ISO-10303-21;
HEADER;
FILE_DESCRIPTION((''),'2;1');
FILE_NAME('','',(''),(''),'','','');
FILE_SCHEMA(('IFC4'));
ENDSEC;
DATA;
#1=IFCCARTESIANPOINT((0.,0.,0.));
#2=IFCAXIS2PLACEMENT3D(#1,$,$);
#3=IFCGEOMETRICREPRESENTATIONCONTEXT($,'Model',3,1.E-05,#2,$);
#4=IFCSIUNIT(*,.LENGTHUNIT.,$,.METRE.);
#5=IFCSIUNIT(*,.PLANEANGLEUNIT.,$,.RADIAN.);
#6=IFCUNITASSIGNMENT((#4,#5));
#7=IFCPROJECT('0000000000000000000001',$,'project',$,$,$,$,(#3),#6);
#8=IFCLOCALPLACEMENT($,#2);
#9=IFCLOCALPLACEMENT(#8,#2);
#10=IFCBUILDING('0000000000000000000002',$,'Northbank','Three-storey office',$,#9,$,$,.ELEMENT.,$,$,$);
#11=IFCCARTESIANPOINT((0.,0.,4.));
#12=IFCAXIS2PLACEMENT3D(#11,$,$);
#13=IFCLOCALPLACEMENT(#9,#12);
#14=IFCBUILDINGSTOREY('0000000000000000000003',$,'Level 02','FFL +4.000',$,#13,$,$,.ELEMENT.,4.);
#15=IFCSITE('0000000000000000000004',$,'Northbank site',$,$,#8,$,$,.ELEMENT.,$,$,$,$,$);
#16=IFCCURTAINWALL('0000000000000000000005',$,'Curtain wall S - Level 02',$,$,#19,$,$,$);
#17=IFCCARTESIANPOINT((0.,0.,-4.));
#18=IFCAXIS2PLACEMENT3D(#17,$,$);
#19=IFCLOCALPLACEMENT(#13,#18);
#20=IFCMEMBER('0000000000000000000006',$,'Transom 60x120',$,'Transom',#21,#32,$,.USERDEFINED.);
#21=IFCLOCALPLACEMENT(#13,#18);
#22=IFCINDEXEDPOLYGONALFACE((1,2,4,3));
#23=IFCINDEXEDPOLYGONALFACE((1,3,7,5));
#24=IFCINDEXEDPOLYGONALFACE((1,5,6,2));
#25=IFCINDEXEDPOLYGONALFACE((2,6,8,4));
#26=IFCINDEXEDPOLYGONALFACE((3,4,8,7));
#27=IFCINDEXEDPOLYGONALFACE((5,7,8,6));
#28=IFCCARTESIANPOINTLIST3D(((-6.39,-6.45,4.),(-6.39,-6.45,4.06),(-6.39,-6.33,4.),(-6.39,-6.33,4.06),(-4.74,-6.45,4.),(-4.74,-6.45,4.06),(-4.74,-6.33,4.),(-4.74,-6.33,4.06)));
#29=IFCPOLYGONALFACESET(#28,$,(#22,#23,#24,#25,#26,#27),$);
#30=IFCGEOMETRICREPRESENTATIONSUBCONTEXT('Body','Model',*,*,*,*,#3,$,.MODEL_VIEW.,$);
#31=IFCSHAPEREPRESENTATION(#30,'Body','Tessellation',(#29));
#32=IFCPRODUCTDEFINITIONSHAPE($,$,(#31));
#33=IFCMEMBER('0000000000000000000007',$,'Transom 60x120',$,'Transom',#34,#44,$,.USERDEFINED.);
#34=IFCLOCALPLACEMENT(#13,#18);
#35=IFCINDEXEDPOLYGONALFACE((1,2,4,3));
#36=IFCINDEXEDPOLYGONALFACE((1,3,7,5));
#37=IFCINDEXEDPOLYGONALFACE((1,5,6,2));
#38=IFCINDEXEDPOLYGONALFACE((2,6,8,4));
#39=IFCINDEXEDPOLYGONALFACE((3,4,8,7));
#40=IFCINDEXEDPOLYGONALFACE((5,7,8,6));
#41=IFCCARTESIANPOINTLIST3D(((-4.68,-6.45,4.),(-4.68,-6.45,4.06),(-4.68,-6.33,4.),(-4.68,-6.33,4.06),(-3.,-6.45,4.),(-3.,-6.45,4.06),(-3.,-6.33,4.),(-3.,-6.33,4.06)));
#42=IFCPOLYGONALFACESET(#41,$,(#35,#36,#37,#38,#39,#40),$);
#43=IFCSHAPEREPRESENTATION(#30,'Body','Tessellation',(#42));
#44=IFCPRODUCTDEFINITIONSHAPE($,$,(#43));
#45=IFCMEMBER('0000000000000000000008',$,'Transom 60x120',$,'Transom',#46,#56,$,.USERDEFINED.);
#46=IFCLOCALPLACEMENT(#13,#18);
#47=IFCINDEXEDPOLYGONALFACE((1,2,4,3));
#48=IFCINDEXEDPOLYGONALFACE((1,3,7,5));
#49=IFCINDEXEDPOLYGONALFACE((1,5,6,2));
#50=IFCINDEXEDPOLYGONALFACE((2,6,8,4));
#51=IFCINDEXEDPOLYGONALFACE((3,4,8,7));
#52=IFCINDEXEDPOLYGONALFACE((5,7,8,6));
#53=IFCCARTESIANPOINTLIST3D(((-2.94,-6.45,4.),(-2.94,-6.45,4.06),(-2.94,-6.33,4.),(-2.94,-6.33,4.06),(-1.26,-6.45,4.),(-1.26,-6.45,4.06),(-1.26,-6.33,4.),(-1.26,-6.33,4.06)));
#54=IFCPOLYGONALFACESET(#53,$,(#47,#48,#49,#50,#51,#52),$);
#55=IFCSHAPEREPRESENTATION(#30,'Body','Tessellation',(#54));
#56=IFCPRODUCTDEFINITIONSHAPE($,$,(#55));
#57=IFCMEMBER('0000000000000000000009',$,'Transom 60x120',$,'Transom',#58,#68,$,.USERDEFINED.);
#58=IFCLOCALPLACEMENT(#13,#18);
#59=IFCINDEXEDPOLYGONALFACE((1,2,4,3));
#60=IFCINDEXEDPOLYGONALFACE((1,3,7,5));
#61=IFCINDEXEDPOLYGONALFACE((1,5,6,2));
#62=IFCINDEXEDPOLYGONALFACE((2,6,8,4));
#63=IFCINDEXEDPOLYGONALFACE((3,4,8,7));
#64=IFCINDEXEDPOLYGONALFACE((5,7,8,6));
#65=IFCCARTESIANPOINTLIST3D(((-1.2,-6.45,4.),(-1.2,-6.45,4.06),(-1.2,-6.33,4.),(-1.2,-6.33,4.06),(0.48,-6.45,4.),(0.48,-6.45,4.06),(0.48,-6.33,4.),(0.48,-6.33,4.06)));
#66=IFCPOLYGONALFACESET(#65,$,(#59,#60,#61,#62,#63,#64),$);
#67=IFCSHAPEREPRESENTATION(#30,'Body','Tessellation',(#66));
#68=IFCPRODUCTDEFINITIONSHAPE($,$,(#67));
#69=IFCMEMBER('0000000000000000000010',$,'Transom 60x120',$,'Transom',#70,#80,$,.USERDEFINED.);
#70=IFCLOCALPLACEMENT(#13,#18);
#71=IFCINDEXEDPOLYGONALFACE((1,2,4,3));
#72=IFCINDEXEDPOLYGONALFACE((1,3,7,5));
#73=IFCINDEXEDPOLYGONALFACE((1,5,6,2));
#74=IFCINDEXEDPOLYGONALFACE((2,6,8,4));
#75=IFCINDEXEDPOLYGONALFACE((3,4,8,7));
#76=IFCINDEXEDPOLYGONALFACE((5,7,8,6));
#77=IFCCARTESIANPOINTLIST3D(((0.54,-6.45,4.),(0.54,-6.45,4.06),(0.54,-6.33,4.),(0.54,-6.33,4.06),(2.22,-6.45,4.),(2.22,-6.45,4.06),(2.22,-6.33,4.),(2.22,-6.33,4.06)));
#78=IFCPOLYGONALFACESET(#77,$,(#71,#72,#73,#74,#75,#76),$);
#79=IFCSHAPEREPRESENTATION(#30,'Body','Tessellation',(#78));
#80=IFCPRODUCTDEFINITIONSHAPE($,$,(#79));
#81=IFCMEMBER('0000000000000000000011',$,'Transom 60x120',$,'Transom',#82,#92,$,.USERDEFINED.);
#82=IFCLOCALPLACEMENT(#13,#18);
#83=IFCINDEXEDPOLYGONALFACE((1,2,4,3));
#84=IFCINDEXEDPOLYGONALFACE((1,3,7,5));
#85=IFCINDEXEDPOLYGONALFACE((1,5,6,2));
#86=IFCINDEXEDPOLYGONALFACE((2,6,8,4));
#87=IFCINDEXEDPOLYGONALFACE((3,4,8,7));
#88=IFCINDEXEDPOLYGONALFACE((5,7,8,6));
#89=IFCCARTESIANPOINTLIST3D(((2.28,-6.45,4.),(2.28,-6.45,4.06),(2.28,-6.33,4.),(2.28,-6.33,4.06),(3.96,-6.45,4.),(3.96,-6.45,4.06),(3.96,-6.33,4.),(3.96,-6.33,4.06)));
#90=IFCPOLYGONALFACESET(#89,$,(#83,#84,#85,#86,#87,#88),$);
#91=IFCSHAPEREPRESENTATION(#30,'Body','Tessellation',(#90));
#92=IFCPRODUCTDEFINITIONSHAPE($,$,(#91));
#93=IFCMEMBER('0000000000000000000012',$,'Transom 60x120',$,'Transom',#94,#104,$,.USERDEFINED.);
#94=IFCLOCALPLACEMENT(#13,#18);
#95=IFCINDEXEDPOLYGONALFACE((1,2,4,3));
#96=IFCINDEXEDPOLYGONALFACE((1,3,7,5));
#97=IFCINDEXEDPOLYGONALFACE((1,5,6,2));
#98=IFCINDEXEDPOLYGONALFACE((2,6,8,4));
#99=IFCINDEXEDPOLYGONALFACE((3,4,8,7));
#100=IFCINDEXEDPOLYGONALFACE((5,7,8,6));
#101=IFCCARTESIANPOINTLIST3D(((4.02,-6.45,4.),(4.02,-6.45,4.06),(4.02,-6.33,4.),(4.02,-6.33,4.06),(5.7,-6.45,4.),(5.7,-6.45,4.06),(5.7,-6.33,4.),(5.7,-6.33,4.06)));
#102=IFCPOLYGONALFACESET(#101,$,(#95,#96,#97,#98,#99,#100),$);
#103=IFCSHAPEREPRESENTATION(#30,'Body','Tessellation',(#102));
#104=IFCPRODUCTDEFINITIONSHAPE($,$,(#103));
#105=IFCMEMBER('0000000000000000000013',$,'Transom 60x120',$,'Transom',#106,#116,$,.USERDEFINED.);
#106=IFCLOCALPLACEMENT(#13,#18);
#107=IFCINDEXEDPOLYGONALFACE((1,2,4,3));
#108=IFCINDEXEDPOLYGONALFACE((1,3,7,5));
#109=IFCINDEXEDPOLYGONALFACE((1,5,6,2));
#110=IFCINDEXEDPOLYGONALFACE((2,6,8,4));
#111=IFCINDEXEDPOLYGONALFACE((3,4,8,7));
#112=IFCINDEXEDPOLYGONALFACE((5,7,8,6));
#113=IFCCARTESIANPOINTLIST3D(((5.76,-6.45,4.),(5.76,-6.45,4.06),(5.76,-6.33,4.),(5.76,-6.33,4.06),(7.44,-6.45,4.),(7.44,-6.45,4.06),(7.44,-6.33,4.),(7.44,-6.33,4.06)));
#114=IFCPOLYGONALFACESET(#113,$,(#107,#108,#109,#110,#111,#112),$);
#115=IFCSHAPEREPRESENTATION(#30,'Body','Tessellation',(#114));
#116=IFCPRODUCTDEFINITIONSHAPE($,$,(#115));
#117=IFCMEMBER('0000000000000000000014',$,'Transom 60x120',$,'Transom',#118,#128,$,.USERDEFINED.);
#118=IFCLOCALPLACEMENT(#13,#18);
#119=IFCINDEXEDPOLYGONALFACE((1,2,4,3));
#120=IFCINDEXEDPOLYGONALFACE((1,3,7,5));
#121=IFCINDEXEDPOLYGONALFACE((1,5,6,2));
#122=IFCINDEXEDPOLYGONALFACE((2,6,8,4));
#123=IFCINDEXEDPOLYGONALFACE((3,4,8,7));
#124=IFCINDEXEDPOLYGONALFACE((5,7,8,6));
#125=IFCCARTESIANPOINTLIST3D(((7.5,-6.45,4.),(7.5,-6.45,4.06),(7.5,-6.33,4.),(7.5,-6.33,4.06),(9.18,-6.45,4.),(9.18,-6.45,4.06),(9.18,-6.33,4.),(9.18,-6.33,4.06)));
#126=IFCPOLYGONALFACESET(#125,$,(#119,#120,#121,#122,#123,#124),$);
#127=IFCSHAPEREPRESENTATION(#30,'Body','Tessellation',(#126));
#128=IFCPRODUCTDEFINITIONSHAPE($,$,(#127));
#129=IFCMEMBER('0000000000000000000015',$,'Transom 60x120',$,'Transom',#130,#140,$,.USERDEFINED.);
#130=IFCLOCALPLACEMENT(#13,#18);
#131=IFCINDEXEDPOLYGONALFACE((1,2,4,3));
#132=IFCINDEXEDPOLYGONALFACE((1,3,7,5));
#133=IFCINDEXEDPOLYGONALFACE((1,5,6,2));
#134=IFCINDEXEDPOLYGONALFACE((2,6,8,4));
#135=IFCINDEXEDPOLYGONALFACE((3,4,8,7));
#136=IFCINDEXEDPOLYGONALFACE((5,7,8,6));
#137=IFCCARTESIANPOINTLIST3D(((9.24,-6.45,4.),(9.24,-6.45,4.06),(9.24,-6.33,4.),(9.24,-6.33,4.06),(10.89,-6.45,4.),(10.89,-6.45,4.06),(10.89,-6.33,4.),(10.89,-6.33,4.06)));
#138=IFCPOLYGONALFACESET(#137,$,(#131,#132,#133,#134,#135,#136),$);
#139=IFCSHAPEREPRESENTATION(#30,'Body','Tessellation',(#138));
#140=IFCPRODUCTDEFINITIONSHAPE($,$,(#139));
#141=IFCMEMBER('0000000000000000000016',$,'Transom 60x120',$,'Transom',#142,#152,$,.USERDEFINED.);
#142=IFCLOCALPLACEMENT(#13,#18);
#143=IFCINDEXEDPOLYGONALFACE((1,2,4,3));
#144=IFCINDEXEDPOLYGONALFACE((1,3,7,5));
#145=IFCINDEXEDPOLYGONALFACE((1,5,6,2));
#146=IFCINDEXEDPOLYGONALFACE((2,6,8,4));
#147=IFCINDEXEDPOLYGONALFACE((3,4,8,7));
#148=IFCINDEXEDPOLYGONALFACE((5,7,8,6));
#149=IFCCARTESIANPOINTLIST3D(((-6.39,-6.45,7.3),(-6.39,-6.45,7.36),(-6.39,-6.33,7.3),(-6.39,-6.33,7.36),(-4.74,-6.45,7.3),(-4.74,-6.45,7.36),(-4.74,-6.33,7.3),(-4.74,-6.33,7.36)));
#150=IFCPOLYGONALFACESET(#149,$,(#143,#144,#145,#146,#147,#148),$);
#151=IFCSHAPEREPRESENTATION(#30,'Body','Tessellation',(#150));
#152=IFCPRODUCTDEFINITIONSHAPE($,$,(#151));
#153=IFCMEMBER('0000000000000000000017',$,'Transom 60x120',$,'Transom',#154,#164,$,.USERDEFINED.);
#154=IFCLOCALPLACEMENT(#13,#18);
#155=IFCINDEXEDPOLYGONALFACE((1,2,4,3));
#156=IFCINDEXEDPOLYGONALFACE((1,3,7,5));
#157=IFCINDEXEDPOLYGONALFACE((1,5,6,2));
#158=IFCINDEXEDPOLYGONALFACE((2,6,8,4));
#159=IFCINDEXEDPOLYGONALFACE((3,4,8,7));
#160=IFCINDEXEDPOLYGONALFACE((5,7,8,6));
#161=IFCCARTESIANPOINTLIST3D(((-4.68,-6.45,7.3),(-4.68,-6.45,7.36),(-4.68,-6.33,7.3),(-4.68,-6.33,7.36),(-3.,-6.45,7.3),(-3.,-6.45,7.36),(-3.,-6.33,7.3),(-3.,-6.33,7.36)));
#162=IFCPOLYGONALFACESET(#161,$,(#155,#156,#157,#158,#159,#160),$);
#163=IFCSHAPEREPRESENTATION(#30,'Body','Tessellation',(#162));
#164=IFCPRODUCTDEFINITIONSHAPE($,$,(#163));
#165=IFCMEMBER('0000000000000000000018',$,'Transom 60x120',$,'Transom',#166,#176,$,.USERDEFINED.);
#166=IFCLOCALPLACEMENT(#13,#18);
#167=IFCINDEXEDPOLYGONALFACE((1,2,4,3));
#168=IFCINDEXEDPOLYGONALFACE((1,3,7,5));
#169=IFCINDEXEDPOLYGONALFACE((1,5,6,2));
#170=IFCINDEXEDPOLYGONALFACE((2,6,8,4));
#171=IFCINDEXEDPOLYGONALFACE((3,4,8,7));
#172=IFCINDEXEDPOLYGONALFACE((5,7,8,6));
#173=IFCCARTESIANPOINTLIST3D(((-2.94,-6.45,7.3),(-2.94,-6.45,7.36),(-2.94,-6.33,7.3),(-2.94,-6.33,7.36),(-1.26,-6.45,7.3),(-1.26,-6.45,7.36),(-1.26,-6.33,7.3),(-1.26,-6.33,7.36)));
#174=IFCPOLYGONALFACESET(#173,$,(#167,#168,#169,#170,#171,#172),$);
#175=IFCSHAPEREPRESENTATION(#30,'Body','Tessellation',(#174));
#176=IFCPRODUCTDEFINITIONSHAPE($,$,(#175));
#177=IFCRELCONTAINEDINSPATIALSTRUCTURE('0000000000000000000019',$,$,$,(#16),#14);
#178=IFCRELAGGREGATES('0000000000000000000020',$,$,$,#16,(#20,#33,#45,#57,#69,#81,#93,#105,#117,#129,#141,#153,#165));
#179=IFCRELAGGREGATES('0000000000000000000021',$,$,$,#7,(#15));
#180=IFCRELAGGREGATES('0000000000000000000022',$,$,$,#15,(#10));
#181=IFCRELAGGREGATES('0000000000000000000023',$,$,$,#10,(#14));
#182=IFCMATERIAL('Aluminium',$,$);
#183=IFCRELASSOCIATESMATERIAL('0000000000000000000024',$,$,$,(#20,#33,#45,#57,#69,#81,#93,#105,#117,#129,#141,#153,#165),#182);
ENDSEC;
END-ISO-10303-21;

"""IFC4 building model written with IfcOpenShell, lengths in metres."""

from ifc_helpers import new_model, si_unit, frame, origin, place, context, subcontext, project, spatial, rectangle, extrude, material, element, aggregate, save


model = new_model("IFC4")

# Units and contexts
model_context = context("Model", 3, precision=1e-05, world=origin())
body_context = subcontext(model_context, "Body", "Model", "MODEL_VIEW")
ifc_project = project(units=[si_unit("LENGTHUNIT", "METRE"), si_unit("PLANEANGLEUNIT", "RADIAN")], contexts=[model_context])

# Site, building, storey
site_placement = place(None, origin())
site = spatial("IfcSite", under=ifc_project, at=site_placement, Name="Northbank site", CompositionType="ELEMENT")
building_placement = place(site_placement, origin())
building = spatial("IfcBuilding", under=site, at=building_placement, Name="Northbank", Description="Three-storey office", CompositionType="ELEMENT")
storey_placement = place(building_placement, frame((0.0, 0.0, 4.0)))
storey = spatial("IfcBuildingStorey", under=building, at=storey_placement, Name="Level 02", Description="FFL +4.000", CompositionType="ELEMENT", Elevation=4.0)

# Curtain wall, members
curtain_wall_placement = place(storey_placement, frame((0.0, 0.0, -4.0)))
curtain_wall = element("IfcCurtainWall", 1, at=curtain_wall_placement, inside=storey, Name="Curtain wall S - Level 02")
ifc_material = material(Name="Aluminium")
member_1_placement = place(storey_placement, frame((0.0, 0.0, -4.0)))
member_1 = element("IfcMember", 2, at=member_1_placement, material=ifc_material, Name="Transom 60x120", ObjectType="Transom", PredefinedType="USERDEFINED", context=body_context, shape_type="SweptSolid", body=[
    extrude(rectangle(XDim=1.65, YDim=0.12), frame((-5.565, -6.39, 4.0)), (0.0, 0.0, 1.0), 0.06),
])
member_2_placement = place(storey_placement, frame((0.0, 0.0, -4.0)))
member_2 = element("IfcMember", 3, at=member_2_placement, material=ifc_material, Name="Transom 60x120", ObjectType="Transom", PredefinedType="USERDEFINED", context=body_context, shape_type="SweptSolid", body=[
    extrude(rectangle(XDim=1.68, YDim=0.12), frame((-3.84, -6.39, 4.0)), (0.0, 0.0, 1.0), 0.06),
])
member_3_placement = place(storey_placement, frame((0.0, 0.0, -4.0)))
member_3 = element("IfcMember", 4, at=member_3_placement, material=ifc_material, Name="Transom 60x120", ObjectType="Transom", PredefinedType="USERDEFINED", context=body_context, shape_type="SweptSolid", body=[
    extrude(rectangle(XDim=1.68, YDim=0.12), frame((-2.1, -6.39, 4.0)), (0.0, 0.0, 1.0), 0.06),
])
member_4_placement = place(storey_placement, frame((0.0, 0.0, -4.0)))
member_4 = element("IfcMember", 5, at=member_4_placement, material=ifc_material, Name="Transom 60x120", ObjectType="Transom", PredefinedType="USERDEFINED", context=body_context, shape_type="SweptSolid", body=[
    extrude(rectangle(XDim=1.68, YDim=0.12), frame((-0.36, -6.39, 4.0)), (0.0, 0.0, 1.0), 0.06),
])
member_5_placement = place(storey_placement, frame((0.0, 0.0, -4.0)))
member_5 = element("IfcMember", 6, at=member_5_placement, material=ifc_material, Name="Transom 60x120", ObjectType="Transom", PredefinedType="USERDEFINED", context=body_context, shape_type="SweptSolid", body=[
    extrude(rectangle(XDim=1.68, YDim=0.12), frame((1.38, -6.39, 4.0)), (0.0, 0.0, 1.0), 0.06),
])
member_6_placement = place(storey_placement, frame((0.0, 0.0, -4.0)))
member_6 = element("IfcMember", 7, at=member_6_placement, material=ifc_material, Name="Transom 60x120", ObjectType="Transom", PredefinedType="USERDEFINED", context=body_context, shape_type="SweptSolid", body=[
    extrude(rectangle(XDim=1.68, YDim=0.12), frame((3.12, -6.39, 4.0)), (0.0, 0.0, 1.0), 0.06),
])
member_7_placement = place(storey_placement, frame((0.0, 0.0, -4.0)))
member_7 = element("IfcMember", 8, at=member_7_placement, material=ifc_material, Name="Transom 60x120", ObjectType="Transom", PredefinedType="USERDEFINED", context=body_context, shape_type="SweptSolid", body=[
    extrude(rectangle(XDim=1.68, YDim=0.12), frame((4.86, -6.39, 4.0)), (0.0, 0.0, 1.0), 0.06),
])
member_8_placement = place(storey_placement, frame((0.0, 0.0, -4.0)))
member_8 = element("IfcMember", 9, at=member_8_placement, material=ifc_material, Name="Transom 60x120", ObjectType="Transom", PredefinedType="USERDEFINED", context=body_context, shape_type="SweptSolid", body=[
    extrude(rectangle(XDim=1.68, YDim=0.12), frame((6.6, -6.39, 4.0)), (0.0, 0.0, 1.0), 0.06),
])
member_9_placement = place(storey_placement, frame((0.0, 0.0, -4.0)))
member_9 = element("IfcMember", 10, at=member_9_placement, material=ifc_material, Name="Transom 60x120", ObjectType="Transom", PredefinedType="USERDEFINED", context=body_context, shape_type="SweptSolid", body=[
    extrude(rectangle(XDim=1.68, YDim=0.12), frame((8.34, -6.39, 4.0)), (0.0, 0.0, 1.0), 0.06),
])
member_10_placement = place(storey_placement, frame((0.0, 0.0, -4.0)))
member_10 = element("IfcMember", 11, at=member_10_placement, material=ifc_material, Name="Transom 60x120", ObjectType="Transom", PredefinedType="USERDEFINED", context=body_context, shape_type="SweptSolid", body=[
    extrude(rectangle(XDim=1.65, YDim=0.12), frame((10.065, -6.39, 4.0)), (0.0, 0.0, 1.0), 0.06),
])
member_11_placement = place(storey_placement, frame((0.0, 0.0, -4.0)))
member_11 = element("IfcMember", 12, at=member_11_placement, material=ifc_material, Name="Transom 60x120", ObjectType="Transom", PredefinedType="USERDEFINED", context=body_context, shape_type="SweptSolid", body=[
    extrude(rectangle(XDim=1.65, YDim=0.12), frame((-5.565, -6.39, 7.3)), (0.0, 0.0, 1.0), 0.06),
])
member_12_placement = place(storey_placement, frame((0.0, 0.0, -4.0)))
member_12 = element("IfcMember", 13, at=member_12_placement, material=ifc_material, Name="Transom 60x120", ObjectType="Transom", PredefinedType="USERDEFINED", context=body_context, shape_type="SweptSolid", body=[
    extrude(rectangle(XDim=1.68, YDim=0.12), frame((-3.84, -6.39, 7.3)), (0.0, 0.0, 1.0), 0.06),
])
member_13_placement = place(storey_placement, frame((0.0, 0.0, -4.0)))
member_13 = element("IfcMember", 14, at=member_13_placement, material=ifc_material, Name="Transom 60x120", ObjectType="Transom", PredefinedType="USERDEFINED", context=body_context, shape_type="SweptSolid", body=[
    extrude(rectangle(XDim=1.68, YDim=0.12), frame((-2.1, -6.39, 7.3)), (0.0, 0.0, 1.0), 0.06),
])
aggregate(curtain_wall, [member_1, member_2, member_3, member_4, member_5, member_6, member_7, member_8, member_9, member_10, member_11, member_12, member_13])

save(model, "model.ifc")
